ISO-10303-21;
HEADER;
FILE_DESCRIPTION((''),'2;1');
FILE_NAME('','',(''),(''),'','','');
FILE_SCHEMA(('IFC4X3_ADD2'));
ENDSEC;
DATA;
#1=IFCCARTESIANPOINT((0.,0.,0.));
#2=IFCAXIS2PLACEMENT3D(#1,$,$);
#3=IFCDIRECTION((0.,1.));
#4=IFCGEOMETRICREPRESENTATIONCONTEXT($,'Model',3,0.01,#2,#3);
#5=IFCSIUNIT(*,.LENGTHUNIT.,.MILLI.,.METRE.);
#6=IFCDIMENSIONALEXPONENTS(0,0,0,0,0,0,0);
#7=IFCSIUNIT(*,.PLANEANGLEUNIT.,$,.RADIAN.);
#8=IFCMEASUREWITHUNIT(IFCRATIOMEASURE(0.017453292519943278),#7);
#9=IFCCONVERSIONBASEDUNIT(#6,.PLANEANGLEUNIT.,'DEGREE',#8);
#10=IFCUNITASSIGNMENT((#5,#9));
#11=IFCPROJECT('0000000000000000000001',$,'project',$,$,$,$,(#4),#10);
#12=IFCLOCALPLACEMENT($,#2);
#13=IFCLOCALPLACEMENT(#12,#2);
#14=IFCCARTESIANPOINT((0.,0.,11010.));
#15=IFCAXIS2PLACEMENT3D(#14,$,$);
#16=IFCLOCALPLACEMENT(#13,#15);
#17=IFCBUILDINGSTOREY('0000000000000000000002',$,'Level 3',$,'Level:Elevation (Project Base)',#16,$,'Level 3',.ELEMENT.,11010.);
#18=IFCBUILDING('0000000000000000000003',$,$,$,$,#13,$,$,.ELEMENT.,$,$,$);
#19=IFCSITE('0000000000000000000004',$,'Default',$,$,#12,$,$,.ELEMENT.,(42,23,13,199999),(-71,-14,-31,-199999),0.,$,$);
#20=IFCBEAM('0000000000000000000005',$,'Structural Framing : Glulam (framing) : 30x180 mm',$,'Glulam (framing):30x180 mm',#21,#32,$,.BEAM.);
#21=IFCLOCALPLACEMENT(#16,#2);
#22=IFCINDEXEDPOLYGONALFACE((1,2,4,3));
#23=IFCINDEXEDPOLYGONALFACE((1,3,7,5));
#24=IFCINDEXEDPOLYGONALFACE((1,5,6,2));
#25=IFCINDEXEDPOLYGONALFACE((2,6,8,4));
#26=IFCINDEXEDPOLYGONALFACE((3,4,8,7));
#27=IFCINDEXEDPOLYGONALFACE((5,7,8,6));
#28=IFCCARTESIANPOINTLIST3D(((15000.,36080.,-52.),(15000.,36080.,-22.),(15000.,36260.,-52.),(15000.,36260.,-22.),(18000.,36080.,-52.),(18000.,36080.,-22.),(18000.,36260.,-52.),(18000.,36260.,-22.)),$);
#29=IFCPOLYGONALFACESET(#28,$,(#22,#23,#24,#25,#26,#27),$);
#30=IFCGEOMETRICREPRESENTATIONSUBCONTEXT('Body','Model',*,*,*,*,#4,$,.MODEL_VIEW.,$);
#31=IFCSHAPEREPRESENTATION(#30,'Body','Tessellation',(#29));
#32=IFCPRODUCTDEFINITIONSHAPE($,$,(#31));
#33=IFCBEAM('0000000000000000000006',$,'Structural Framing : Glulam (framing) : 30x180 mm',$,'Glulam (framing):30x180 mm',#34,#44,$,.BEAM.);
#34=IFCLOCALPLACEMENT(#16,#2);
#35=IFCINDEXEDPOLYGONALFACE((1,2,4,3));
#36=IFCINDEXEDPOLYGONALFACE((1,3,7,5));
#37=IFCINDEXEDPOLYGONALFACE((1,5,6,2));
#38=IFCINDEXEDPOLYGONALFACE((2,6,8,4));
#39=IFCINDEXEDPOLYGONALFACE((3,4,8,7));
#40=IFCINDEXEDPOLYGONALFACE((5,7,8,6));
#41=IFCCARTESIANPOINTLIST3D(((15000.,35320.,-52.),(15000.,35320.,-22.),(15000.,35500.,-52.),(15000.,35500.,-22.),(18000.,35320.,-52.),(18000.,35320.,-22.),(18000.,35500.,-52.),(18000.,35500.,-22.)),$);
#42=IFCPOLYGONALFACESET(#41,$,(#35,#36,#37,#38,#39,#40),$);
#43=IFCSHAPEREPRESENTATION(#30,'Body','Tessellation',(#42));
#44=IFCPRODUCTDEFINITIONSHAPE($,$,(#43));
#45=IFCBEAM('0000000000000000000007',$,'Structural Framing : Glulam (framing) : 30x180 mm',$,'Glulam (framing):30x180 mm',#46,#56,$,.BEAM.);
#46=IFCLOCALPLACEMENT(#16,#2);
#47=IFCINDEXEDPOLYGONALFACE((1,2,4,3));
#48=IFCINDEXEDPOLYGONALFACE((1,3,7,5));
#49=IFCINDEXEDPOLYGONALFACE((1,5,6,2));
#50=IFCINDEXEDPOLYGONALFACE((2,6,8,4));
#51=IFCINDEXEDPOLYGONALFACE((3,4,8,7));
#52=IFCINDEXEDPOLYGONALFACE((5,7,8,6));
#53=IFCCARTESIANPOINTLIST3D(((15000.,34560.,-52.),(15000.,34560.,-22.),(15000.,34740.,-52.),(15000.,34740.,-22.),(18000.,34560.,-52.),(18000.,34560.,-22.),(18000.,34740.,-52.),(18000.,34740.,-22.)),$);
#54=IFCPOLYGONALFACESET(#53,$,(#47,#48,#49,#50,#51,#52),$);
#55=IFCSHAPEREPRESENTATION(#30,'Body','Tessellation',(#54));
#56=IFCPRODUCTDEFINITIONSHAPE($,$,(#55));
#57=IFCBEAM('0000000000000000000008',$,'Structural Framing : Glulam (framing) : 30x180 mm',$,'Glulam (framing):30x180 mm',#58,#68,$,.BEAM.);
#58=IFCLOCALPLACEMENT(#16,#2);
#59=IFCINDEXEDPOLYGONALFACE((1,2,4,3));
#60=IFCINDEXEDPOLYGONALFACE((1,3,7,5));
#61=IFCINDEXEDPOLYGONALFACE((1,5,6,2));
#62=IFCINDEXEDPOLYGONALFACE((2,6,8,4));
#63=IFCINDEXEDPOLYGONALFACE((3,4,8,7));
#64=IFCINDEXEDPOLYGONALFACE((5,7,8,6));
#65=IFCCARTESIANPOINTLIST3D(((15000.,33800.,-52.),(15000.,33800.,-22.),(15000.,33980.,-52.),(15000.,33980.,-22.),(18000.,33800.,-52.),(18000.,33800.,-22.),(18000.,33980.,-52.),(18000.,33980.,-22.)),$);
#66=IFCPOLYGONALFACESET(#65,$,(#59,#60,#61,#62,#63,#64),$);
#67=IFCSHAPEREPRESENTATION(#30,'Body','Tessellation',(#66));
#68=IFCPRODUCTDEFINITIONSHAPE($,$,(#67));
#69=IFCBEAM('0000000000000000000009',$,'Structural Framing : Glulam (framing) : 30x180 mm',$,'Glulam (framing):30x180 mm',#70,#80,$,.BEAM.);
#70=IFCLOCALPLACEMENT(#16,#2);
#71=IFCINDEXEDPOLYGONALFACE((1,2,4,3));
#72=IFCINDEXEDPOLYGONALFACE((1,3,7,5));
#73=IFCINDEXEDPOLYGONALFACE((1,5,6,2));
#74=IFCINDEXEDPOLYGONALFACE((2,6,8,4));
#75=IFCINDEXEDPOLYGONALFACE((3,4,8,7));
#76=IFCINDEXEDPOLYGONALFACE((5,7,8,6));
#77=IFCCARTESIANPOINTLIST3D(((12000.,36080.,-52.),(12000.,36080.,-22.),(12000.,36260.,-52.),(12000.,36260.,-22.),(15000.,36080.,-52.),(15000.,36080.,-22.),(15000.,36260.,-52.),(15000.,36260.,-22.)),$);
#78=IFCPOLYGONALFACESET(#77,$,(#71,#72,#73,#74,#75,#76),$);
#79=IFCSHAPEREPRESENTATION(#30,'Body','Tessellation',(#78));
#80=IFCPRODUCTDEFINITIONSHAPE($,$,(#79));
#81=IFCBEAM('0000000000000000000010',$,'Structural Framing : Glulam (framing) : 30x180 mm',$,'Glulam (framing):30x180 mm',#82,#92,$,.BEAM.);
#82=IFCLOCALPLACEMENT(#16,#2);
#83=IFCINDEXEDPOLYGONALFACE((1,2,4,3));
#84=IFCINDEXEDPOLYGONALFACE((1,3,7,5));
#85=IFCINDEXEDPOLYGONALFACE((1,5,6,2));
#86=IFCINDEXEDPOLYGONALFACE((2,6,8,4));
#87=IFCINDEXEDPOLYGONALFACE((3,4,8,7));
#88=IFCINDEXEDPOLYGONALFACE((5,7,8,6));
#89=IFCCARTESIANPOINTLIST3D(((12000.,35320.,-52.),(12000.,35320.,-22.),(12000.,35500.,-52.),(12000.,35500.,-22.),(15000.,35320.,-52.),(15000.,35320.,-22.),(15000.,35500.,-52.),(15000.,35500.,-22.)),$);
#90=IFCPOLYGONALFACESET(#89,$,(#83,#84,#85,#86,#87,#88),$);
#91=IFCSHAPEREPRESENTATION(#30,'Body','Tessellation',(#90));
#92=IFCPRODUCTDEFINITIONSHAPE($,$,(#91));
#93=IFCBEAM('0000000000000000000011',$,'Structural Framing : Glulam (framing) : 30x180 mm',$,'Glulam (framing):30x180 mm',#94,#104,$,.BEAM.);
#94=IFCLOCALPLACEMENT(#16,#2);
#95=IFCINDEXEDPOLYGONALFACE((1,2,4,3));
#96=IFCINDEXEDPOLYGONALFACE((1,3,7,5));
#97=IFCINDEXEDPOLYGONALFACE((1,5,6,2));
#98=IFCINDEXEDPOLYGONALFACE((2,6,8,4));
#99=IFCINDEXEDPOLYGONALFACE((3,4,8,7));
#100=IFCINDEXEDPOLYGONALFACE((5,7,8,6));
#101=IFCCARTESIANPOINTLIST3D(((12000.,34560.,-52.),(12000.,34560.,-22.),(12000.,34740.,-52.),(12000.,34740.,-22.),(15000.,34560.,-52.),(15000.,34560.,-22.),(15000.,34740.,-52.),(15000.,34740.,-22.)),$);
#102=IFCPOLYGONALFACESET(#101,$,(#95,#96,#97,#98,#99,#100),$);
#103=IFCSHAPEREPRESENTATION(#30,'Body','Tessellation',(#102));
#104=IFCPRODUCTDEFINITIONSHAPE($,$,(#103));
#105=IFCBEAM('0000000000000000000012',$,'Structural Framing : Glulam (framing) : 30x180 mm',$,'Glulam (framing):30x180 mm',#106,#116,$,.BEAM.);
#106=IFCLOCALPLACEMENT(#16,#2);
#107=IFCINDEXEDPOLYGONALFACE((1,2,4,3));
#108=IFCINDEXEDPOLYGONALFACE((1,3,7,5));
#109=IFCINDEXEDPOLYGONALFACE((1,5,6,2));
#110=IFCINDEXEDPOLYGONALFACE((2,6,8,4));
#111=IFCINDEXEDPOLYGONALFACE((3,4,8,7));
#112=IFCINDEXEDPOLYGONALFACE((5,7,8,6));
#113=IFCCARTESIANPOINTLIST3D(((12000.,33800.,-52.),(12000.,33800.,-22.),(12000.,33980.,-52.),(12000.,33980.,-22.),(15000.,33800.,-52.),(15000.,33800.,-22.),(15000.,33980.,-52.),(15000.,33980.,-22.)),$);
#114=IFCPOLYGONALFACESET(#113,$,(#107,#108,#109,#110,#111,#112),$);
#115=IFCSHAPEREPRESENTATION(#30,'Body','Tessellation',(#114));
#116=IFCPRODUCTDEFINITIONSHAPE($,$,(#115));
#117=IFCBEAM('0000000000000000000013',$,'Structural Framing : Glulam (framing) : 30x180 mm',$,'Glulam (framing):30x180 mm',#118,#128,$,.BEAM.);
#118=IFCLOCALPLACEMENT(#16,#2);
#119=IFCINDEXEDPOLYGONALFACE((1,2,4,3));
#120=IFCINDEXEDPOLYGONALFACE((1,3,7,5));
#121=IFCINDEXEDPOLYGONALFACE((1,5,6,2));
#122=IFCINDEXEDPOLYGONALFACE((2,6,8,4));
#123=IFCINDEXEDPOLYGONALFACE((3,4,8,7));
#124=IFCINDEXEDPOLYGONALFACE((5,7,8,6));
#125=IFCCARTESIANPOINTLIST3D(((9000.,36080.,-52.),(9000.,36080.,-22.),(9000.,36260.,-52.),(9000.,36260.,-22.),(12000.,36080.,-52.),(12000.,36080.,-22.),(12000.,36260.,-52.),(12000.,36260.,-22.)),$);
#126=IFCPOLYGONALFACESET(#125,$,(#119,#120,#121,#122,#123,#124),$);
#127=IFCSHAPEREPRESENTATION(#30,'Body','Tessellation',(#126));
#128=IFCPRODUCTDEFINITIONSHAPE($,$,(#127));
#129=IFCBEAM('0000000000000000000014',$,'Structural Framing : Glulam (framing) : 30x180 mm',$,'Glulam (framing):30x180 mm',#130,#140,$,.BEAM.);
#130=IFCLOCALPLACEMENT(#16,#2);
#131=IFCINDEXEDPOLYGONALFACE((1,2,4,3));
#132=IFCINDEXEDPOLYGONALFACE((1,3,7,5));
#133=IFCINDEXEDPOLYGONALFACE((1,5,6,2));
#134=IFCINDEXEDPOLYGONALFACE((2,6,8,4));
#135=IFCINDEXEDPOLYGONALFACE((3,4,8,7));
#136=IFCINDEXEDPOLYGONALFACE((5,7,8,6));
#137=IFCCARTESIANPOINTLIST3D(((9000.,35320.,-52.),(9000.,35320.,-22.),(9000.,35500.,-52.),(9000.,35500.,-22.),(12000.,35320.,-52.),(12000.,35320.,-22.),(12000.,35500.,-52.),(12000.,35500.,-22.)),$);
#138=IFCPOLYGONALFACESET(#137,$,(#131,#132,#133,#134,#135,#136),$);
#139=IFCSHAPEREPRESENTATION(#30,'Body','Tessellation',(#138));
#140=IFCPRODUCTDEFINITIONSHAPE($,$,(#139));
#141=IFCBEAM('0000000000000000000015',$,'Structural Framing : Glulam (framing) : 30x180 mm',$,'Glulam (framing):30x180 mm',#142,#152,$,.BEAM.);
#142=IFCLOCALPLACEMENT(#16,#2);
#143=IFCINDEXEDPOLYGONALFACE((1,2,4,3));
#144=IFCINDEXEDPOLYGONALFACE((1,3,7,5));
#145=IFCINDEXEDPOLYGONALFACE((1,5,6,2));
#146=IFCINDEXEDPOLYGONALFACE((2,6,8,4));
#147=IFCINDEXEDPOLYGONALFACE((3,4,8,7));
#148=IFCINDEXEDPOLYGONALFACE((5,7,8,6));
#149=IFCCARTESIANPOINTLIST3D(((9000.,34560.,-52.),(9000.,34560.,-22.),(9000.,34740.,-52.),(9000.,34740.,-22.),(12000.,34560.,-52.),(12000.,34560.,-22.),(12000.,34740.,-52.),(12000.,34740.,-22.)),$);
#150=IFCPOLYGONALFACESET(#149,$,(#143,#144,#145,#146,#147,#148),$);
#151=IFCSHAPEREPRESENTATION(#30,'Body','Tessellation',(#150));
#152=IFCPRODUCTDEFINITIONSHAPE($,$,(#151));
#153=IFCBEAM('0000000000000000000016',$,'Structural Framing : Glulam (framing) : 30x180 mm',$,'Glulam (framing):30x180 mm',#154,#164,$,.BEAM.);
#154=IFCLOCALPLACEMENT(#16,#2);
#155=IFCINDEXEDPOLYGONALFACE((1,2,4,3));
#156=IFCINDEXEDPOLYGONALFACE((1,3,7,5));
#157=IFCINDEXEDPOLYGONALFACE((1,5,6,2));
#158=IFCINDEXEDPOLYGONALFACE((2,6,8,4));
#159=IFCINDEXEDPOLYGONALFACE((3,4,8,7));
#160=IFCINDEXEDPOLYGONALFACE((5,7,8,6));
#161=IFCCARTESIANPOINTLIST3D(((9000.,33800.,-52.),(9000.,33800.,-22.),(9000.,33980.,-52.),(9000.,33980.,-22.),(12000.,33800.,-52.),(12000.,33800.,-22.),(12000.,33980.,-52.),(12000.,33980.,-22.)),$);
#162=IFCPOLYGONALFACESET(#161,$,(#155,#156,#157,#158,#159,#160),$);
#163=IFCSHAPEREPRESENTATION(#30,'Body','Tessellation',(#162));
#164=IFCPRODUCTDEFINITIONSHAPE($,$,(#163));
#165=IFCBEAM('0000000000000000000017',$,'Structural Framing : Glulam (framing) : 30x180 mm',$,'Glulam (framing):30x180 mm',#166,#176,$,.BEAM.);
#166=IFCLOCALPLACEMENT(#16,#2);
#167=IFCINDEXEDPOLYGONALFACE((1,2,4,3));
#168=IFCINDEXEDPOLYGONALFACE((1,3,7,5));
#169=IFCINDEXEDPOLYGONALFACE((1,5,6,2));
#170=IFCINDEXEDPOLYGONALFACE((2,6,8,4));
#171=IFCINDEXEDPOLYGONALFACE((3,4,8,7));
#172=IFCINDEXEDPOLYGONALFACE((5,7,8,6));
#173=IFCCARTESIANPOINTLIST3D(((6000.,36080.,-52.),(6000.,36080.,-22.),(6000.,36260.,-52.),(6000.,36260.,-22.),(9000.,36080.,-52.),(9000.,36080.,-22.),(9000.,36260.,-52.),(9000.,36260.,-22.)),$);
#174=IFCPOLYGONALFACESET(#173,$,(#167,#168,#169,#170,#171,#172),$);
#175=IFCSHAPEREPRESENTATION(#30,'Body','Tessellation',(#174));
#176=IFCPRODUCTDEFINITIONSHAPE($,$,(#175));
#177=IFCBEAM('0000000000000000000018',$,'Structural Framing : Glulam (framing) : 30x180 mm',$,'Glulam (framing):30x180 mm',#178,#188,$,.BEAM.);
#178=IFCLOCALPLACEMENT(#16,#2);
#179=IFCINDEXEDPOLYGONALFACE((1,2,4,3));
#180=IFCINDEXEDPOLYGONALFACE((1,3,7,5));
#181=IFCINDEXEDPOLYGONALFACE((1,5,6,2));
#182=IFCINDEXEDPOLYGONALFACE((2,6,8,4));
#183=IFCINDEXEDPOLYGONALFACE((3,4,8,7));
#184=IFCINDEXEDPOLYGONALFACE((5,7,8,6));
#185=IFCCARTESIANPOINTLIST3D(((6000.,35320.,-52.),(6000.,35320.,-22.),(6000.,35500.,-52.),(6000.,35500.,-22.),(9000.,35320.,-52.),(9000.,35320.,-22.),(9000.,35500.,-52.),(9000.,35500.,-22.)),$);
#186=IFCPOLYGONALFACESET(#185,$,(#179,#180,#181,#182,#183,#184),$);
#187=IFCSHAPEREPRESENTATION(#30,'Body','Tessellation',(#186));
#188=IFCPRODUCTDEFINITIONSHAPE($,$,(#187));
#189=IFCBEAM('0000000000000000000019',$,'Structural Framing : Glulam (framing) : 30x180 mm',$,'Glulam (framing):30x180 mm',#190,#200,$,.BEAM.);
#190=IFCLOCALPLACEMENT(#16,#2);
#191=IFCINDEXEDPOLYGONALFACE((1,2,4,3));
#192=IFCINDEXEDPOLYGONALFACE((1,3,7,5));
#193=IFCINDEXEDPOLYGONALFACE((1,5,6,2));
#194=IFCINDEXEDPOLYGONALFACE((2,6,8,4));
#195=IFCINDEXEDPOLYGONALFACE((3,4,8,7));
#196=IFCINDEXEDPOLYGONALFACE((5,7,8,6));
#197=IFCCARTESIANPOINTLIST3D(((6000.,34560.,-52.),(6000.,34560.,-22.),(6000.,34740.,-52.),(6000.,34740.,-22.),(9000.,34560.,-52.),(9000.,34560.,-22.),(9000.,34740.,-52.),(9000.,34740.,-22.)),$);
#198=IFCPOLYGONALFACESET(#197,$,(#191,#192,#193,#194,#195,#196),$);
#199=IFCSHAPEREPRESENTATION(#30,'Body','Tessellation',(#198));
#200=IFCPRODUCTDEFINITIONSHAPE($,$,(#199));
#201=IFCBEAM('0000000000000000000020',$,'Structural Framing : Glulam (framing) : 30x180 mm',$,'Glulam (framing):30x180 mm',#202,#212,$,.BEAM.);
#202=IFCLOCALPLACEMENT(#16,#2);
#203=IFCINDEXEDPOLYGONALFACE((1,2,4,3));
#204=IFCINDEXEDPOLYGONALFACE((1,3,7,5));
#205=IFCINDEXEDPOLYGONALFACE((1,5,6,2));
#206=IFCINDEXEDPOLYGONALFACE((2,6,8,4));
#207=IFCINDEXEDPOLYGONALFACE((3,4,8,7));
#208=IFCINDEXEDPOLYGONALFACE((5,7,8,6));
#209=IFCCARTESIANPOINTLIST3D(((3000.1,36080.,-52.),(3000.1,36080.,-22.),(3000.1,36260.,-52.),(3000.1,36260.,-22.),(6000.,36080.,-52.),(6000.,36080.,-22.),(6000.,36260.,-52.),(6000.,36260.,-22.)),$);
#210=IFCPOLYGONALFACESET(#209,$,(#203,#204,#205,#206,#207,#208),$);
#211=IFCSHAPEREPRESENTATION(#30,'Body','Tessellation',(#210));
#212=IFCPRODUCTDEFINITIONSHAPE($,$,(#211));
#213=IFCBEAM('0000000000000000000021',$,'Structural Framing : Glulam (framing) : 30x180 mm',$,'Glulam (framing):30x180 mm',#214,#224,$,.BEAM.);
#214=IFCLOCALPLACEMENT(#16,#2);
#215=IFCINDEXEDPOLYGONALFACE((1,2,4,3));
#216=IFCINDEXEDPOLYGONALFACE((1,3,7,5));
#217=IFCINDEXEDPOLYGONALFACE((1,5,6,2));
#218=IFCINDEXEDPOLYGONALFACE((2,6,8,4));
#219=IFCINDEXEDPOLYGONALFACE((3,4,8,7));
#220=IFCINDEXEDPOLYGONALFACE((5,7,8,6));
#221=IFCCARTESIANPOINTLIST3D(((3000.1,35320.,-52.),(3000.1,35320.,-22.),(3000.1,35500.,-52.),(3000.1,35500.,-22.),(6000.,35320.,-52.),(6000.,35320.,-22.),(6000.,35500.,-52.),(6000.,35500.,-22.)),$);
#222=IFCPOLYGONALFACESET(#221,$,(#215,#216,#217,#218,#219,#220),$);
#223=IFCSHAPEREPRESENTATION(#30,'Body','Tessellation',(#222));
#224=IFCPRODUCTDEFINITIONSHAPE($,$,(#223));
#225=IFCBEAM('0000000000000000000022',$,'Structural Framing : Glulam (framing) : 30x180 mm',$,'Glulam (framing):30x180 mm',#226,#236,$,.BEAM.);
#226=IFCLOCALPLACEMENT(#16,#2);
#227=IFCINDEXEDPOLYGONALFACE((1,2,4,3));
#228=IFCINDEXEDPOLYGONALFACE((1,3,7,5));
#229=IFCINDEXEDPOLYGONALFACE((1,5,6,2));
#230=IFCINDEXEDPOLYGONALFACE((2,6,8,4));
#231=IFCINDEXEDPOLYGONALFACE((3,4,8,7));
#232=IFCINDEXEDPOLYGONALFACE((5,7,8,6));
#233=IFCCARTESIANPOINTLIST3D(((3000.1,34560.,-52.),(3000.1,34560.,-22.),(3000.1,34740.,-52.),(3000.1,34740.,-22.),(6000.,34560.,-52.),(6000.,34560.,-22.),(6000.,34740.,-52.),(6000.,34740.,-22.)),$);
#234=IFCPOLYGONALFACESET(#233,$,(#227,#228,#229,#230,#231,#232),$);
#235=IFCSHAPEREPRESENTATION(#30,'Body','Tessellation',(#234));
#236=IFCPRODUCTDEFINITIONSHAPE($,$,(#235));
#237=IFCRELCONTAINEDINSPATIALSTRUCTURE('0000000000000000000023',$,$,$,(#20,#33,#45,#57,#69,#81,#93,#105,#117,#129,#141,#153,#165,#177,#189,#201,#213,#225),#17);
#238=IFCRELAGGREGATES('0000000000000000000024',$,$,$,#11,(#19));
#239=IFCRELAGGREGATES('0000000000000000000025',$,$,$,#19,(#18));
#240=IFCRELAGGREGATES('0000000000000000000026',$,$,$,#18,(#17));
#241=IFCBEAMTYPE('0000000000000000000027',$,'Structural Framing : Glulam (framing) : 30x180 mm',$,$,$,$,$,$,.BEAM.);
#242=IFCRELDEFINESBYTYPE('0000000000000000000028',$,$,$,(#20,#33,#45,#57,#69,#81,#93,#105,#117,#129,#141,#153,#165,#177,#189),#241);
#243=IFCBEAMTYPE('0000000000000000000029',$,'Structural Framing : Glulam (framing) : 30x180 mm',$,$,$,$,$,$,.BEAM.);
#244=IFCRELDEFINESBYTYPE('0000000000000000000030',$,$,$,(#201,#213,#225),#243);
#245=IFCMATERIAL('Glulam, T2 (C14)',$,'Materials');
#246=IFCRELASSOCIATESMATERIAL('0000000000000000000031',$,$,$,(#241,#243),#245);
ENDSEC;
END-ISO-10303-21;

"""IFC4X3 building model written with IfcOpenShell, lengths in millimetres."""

from ifc_helpers import new_model, entity, si_unit, converted_unit, direction, frame, origin, origin_2d_with_axis, place, context, subcontext, project, spatial, rectangle, extrude, source, transform, mapped, material, material_profile, profile_set, type_object, type_shapes, element, save


model = new_model("IFC4X3")

# Units and contexts
model_context = context("Model", 3, precision=0.01, world=origin(), true_north=direction((0.0, 1.0)))
body_context = subcontext(model_context, "Body", "Model", "MODEL_VIEW")
ifc_project = project(units=[si_unit("LENGTHUNIT", "METRE", prefix="MILLI"), converted_unit("PLANEANGLEUNIT", "DEGREE", entity("IfcRatioMeasure", 0.017453292519943278), si_unit("PLANEANGLEUNIT", "RADIAN"), dimensions=[0, 0, 0, 0, 0, 0, 0])], contexts=[model_context])

# Site, building, storey
site_placement = place(None, origin())
site = spatial("IfcSite", under=ifc_project, at=site_placement, Name="Default", CompositionType="ELEMENT", RefLatitude=(42, 23, 13, 199999), RefLongitude=(-71, -14, -31, -199999), RefElevation=0.0)
building_placement = place(site_placement, origin())
building = spatial("IfcBuilding", under=site, at=building_placement, CompositionType="ELEMENT")
storey_placement = place(building_placement, frame((0.0, 0.0, 11010.0)))
storey = spatial("IfcBuildingStorey", under=building, at=storey_placement, Name="Level 3", ObjectType="Level:Elevation (Project Base)", LongName="Level 3", CompositionType="ELEMENT", Elevation=11010.0)

# Beams
ifc_material_1 = material(Name="Glulam, T2 (C14)", Category="Materials")
ifc_material_profile_1 = material_profile(ifc_material_1, rectangle(XDim=30.0, YDim=180.0, at=origin_2d_with_axis()), Name="30x180 mm")
ifc_profile_set_1 = profile_set([ifc_material_profile_1], Name="30x180 mm")
beam_type_1 = type_object("IfcBeamType", Name="Structural Framing : Glulam (framing) : 30x180 mm", PredefinedType="BEAM", material=ifc_profile_set_1)
shared_shape_1 = source(origin(), body_context, "Body", "SweptSolid", [
    extrude(rectangle(XDim=30.0, YDim=180.0, at=origin_2d_with_axis()), frame((500.0, 0.0, 0.0), z_axis=(1.0, 0.0, 0.0), x_axis=(0.0, 0.0, -1.0)), (0.0, 0.0, 1.0), 3000.0),
])
type_shapes(beam_type_1, [shared_shape_1])
for number, where, name in (
    (1, (14500.0, 36170.0, -37.0), "Structural Framing : Glulam (framing) : 30x180 mm"),
    (2, (14500.0, 35410.0, -37.0), "Structural Framing : Glulam (framing) : 30x180 mm"),
    (3, (14500.0, 34650.0, -37.0), "Structural Framing : Glulam (framing) : 30x180 mm"),
    (4, (14500.0, 33890.0, -37.0), "Structural Framing : Glulam (framing) : 30x180 mm"),
    (5, (11500.0, 36170.0, -37.0), "Structural Framing : Glulam (framing) : 30x180 mm"),
    (6, (11500.0, 35410.0, -37.0), "Structural Framing : Glulam (framing) : 30x180 mm"),
    (7, (11500.0, 34650.0, -37.0), "Structural Framing : Glulam (framing) : 30x180 mm"),
    (8, (11500.0, 33890.0, -37.0), "Structural Framing : Glulam (framing) : 30x180 mm"),
    (9, (8500.0, 36170.0, -37.0), "Structural Framing : Glulam (framing) : 30x180 mm"),
    (10, (8500.0, 35410.0, -37.0), "Structural Framing : Glulam (framing) : 30x180 mm"),
    (11, (8500.0, 34650.0, -37.0), "Structural Framing : Glulam (framing) : 30x180 mm"),
    (12, (8500.0, 33890.0, -37.0), "Structural Framing : Glulam (framing) : 30x180 mm"),
    (13, (5500.0, 36170.0, -37.0), "Structural Framing : Glulam (framing) : 30x180 mm"),
    (14, (5500.0, 35410.0, -37.0), "Structural Framing : Glulam (framing) : 30x180 mm"),
    (15, (5500.0, 34650.0, -37.0), "Structural Framing : Glulam (framing) : 30x180 mm"),
):
    element("IfcBeam", number, at=place(storey_placement, frame(where)), inside=storey, type_object=beam_type_1, Name=name, ObjectType="Glulam (framing):30x180 mm", PredefinedType="BEAM", context=body_context, shape_type="MappedRepresentation", body=[
        mapped(shared_shape_1, transform((0.0, 0.0, 0.0), scale=1.0)),
    ])
beam_type_2 = type_object("IfcBeamType", Name="Structural Framing : Glulam (framing) : 30x180 mm", PredefinedType="BEAM", material=ifc_profile_set_1)
shared_shape_2 = source(origin(), body_context, "Body", "SweptSolid", [
    extrude(rectangle(XDim=30.0, YDim=180.0, at=origin_2d_with_axis()), frame((500.0, 0.0, 0.0), z_axis=(1.0, 0.0, 0.0), x_axis=(0.0, 0.0, -1.0)), (0.0, 0.0, 1.0), 2999.9),
])
type_shapes(beam_type_2, [shared_shape_2])
for number, where, name in (
    (16, (2500.1, 36170.0, -37.0), "Structural Framing : Glulam (framing) : 30x180 mm"),
    (17, (2500.1, 35410.0, -37.0), "Structural Framing : Glulam (framing) : 30x180 mm"),
    (18, (2500.1, 34650.0, -37.0), "Structural Framing : Glulam (framing) : 30x180 mm"),
):
    element("IfcBeam", number, at=place(storey_placement, frame(where)), inside=storey, type_object=beam_type_2, Name=name, ObjectType="Glulam (framing):30x180 mm", PredefinedType="BEAM", context=body_context, shape_type="MappedRepresentation", body=[
        mapped(shared_shape_2, transform((0.0, 0.0, 0.0), scale=1.0)),
    ])

save(model, "model.ifc")
